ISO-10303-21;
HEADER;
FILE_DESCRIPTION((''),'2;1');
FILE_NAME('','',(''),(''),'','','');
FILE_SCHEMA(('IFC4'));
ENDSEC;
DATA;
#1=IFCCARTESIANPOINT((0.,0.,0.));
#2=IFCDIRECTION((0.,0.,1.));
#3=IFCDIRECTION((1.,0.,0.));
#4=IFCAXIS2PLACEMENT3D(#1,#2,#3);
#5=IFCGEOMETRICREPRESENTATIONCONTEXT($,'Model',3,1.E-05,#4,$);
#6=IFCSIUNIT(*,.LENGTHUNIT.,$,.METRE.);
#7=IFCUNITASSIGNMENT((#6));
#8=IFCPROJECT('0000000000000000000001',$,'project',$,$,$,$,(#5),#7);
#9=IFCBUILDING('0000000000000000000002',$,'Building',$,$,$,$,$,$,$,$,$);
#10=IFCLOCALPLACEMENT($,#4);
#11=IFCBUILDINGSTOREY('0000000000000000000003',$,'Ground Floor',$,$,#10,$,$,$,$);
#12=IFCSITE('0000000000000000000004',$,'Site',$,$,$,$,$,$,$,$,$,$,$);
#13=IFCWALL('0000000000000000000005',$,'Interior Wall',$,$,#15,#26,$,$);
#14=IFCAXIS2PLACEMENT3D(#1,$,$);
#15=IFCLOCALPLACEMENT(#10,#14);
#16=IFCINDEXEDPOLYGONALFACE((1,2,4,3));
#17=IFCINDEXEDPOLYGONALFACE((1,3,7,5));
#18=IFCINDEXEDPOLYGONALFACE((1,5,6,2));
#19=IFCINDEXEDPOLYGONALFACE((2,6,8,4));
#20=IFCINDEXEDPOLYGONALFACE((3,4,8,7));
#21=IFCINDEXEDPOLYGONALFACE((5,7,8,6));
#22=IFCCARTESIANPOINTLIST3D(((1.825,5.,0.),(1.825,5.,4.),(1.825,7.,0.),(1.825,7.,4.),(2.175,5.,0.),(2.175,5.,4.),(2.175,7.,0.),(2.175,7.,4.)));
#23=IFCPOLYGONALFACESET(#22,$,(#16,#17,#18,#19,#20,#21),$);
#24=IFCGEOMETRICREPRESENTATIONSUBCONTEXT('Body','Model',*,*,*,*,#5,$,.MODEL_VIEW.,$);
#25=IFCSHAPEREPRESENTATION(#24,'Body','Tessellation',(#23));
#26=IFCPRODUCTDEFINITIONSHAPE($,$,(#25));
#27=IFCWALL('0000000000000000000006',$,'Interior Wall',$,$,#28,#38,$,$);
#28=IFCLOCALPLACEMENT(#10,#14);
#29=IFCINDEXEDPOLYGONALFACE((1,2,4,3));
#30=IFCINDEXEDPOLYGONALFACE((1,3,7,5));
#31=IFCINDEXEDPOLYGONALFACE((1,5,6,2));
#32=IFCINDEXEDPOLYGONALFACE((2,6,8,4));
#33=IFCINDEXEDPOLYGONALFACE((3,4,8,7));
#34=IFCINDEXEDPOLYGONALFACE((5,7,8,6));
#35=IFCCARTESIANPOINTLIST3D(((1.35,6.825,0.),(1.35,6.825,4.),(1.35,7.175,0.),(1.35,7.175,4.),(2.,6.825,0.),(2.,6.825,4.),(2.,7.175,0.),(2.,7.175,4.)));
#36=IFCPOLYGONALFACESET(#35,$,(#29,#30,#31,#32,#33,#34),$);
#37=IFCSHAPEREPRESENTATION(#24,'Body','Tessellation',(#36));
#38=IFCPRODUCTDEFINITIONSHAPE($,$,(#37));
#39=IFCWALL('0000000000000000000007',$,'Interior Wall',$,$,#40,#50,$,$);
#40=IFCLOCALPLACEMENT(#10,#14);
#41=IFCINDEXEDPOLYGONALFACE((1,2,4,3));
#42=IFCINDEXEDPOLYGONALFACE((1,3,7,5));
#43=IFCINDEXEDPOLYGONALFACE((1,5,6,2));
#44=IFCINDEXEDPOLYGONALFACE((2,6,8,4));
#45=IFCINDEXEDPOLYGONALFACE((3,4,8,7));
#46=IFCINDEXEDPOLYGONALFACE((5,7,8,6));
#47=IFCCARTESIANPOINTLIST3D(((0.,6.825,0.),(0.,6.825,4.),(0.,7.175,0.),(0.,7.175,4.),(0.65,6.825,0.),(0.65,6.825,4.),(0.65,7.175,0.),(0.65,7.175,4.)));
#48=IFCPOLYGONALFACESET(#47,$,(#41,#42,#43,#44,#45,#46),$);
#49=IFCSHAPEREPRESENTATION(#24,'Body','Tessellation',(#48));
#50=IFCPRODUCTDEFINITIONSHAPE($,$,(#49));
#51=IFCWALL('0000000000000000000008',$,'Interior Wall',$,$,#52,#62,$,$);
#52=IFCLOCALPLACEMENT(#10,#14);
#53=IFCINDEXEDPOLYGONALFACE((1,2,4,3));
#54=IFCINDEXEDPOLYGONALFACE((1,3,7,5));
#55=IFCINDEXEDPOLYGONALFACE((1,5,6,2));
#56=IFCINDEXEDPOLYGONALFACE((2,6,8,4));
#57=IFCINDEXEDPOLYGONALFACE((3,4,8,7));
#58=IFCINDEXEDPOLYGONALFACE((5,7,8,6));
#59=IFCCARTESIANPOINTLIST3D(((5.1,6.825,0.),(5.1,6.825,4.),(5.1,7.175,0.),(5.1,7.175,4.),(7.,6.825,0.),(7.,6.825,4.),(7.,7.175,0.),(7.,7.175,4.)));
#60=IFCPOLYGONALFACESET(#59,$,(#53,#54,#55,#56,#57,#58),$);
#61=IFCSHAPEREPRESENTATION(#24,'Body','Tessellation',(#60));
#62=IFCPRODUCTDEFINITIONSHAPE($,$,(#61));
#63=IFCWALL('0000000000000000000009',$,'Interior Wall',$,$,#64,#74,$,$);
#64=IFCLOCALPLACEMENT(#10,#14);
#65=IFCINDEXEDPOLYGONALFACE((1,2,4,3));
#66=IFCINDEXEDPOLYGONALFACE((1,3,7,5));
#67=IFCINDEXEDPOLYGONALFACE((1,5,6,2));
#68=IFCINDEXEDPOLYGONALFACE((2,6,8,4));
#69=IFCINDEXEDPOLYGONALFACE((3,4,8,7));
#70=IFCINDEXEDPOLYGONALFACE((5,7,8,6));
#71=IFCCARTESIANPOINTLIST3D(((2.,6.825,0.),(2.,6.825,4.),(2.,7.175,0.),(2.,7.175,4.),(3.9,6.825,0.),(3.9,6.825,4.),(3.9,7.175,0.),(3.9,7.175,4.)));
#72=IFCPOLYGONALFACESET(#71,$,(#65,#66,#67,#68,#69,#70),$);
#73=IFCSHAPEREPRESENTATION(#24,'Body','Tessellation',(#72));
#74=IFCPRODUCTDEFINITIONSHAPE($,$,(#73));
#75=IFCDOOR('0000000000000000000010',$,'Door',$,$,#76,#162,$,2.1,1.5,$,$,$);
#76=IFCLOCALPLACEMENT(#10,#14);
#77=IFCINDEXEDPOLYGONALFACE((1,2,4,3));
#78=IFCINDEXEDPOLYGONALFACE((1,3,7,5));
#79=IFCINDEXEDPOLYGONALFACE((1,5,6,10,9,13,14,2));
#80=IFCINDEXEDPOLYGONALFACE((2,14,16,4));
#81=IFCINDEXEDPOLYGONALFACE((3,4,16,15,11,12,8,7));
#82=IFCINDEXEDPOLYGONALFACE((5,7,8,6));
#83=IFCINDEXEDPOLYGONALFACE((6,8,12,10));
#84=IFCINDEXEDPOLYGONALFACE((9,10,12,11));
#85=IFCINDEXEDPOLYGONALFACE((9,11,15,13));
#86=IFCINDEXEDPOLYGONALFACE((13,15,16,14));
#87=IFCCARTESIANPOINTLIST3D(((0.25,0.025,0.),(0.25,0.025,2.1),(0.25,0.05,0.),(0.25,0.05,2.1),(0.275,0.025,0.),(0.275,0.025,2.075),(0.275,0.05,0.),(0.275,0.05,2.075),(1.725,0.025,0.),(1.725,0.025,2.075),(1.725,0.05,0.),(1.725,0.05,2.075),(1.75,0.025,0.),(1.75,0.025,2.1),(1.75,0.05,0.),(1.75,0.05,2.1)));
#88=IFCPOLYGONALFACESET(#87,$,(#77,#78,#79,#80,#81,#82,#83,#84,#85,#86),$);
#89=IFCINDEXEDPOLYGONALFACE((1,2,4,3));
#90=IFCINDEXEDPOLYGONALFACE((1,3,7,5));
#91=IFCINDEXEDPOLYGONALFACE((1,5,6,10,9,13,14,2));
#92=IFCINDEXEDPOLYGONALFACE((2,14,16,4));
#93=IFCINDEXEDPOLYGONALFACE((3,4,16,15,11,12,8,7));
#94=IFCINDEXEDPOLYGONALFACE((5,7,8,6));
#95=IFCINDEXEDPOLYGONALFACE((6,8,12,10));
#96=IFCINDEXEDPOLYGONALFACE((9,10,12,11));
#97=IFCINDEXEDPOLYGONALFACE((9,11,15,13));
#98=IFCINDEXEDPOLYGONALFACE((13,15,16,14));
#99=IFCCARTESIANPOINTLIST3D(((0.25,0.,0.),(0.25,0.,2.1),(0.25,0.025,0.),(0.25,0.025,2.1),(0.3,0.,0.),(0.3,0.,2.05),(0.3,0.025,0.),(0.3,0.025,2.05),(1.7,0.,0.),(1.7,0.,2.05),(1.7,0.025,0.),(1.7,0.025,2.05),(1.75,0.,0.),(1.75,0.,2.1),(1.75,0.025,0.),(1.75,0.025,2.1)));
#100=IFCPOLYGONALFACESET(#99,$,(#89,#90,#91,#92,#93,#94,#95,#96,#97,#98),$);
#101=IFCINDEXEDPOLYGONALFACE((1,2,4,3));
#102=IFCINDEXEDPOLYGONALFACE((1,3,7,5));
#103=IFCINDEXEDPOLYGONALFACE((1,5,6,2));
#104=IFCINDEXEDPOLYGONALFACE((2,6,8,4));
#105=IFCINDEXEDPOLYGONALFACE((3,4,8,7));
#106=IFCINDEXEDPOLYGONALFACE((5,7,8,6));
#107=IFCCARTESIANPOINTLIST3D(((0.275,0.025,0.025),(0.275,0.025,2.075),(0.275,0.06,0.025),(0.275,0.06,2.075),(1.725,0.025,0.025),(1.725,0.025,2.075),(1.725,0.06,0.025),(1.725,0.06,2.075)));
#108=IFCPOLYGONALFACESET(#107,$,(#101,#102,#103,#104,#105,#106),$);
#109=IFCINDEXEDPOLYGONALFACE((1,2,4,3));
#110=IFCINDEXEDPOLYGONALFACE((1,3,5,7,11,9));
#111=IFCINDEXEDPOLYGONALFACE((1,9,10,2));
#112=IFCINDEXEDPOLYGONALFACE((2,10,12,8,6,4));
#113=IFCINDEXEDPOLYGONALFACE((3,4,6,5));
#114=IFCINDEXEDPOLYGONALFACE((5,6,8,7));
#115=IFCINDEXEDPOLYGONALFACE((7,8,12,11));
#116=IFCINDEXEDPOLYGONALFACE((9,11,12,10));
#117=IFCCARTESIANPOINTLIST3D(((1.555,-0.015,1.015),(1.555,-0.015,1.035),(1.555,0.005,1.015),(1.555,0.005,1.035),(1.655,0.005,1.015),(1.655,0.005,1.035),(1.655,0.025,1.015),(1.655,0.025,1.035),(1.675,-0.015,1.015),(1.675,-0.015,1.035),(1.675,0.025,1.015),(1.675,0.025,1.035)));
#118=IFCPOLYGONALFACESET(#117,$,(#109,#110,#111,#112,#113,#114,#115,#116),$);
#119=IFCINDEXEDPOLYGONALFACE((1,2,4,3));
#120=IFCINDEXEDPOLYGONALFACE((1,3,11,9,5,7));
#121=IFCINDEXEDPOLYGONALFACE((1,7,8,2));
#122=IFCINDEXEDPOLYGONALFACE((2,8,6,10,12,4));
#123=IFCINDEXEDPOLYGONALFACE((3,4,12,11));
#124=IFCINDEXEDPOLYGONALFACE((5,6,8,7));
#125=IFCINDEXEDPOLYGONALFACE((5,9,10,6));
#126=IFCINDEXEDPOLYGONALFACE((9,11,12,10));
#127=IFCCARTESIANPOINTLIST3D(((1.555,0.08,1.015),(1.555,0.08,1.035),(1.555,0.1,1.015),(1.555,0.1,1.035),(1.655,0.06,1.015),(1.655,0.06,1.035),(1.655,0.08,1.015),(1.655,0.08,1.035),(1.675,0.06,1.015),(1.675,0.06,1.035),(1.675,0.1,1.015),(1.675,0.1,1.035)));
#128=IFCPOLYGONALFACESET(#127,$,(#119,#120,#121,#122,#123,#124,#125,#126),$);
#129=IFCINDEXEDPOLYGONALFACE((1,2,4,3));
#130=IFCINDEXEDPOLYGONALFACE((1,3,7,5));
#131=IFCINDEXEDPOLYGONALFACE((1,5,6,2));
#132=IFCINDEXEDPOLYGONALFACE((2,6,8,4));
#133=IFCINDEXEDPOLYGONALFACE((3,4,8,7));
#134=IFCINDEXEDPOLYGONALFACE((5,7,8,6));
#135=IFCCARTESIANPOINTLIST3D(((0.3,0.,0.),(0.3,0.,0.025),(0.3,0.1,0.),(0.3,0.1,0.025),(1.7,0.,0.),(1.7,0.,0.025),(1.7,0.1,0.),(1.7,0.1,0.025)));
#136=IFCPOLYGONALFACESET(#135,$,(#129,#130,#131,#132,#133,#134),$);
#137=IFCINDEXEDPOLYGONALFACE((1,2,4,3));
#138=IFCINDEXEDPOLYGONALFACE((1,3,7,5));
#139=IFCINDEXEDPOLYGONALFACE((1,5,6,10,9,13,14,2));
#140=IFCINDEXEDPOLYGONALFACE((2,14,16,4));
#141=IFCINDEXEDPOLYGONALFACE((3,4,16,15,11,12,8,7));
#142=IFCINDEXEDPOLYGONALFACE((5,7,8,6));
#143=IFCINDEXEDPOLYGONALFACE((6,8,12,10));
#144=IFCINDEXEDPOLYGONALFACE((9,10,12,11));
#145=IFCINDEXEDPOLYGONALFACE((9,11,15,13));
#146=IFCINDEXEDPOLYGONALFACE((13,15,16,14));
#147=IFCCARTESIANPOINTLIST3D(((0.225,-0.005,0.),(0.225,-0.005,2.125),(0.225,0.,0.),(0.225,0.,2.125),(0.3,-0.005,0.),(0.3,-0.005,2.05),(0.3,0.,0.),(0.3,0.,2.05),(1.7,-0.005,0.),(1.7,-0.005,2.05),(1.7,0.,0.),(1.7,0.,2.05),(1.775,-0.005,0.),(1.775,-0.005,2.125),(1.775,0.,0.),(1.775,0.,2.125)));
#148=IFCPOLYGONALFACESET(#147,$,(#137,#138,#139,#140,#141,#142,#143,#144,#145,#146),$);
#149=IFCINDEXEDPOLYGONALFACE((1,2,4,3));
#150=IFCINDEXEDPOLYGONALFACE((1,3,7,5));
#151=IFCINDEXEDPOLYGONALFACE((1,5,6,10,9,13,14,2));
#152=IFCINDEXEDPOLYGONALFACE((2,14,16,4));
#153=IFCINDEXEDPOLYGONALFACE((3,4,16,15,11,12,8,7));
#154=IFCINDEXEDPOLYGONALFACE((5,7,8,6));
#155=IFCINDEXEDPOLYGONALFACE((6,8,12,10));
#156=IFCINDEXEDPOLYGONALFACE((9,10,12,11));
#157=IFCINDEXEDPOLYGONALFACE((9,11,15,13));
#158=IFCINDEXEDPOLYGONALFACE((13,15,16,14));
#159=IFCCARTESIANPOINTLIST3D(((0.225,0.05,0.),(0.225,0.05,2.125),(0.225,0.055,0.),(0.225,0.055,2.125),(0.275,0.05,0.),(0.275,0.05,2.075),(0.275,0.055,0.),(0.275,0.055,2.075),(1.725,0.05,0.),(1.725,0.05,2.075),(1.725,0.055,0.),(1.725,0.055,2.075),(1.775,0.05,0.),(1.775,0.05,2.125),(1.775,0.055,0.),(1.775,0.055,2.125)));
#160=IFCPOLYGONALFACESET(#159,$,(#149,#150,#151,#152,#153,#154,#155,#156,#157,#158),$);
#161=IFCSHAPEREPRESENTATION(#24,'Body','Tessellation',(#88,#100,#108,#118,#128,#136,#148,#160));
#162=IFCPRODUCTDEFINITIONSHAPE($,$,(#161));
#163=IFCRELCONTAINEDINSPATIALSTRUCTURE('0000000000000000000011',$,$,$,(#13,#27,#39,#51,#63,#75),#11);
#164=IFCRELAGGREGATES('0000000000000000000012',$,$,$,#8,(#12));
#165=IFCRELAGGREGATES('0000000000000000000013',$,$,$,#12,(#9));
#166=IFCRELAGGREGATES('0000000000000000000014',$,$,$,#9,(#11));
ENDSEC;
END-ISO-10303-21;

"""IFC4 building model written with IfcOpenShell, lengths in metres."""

from ifc_helpers import new_model, si_unit, frame, origin_with_axes, place, context, subcontext, project, spatial, line, indexed_curve, outline, extrude, element, save


model = new_model("IFC4")

# Units and contexts
model_context = context("Model", 3, precision=1e-05, world=origin_with_axes())
body_context = subcontext(model_context, "Body", "Model", "MODEL_VIEW")
ifc_project = project(units=[si_unit("LENGTHUNIT", "METRE")], contexts=[model_context])

# Site, building, storey
site = spatial("IfcSite", under=ifc_project, Name="Site")
building = spatial("IfcBuilding", under=site, Name="Building")
storey_placement = place(None, origin_with_axes())
storey = spatial("IfcBuildingStorey", under=building, at=storey_placement, Name="Ground Floor")

# Walls
wall_1_placement = place(storey_placement, frame((2.0, 5.0, 0.0), z_axis=(0.0, 0.0, 1.0), x_axis=(0.0, 1.0, 0.0)))
element("IfcWall", 1, at=wall_1_placement, inside=storey, Name="Interior Wall", context=body_context, shape_type="SweptSolid", body=[
    extrude(outline(indexed_curve([(0.0, 0.0), (0.0, 0.35), (2.0, 0.35), (2.0, 0.0), (0.0, 0.0)], self_intersect=False)), frame((0.0, -0.175, 0.0), z_axis=(0.0, 0.0, 1.0), x_axis=(1.0, 0.0, 0.0)), (0.0, 0.0, 1.0), 4.0),
])
for number, where, z_axis, x_axis, name in (
    (2, (2.0, 7.0, 0.0), (0.0, 0.0, 1.0), (-1.0, 0.0, 0.0), "Interior Wall"),
    (3, (0.65, 7.0, 0.0), (0.0, 0.0, 1.0), (-1.0, 0.0, 0.0), "Interior Wall"),
):
    element("IfcWall", number, at=place(storey_placement, frame(where, z_axis=z_axis, x_axis=x_axis)), inside=storey, Name=name, context=body_context, shape_type="SweptSolid", body=[
        extrude(outline(indexed_curve([(0.0, 0.0), (0.0, 0.35), (0.65, 0.35), (0.65, 0.0), (0.0, 0.0)], self_intersect=False)), frame((0.0, -0.175, 0.0), z_axis=(0.0, 0.0, 1.0), x_axis=(1.0, 0.0, 0.0)), (0.0, 0.0, 1.0), 4.0),
    ])
wall_2_placement = place(storey_placement, frame((7.0, 7.0, 0.0), z_axis=(0.0, 0.0, 1.0), x_axis=(-1.0, 0.0, 0.0)))
element("IfcWall", 4, at=wall_2_placement, inside=storey, Name="Interior Wall", context=body_context, shape_type="SweptSolid", body=[
    extrude(outline(indexed_curve([(0.0, 0.0), (0.0, 0.35), (1.9, 0.35), (1.9, 0.0), (0.0, 0.0)], self_intersect=False)), frame((0.0, -0.175, 0.0), z_axis=(0.0, 0.0, 1.0), x_axis=(1.0, 0.0, 0.0)), (0.0, 0.0, 1.0), 4.0),
])
wall_3_placement = place(storey_placement, frame((3.9, 7.0, 0.0), z_axis=(0.0, 0.0, 1.0), x_axis=(-1.0, 0.0, 0.0)))
element("IfcWall", 5, at=wall_3_placement, inside=storey, Name="Interior Wall", context=body_context, shape_type="SweptSolid", body=[
    extrude(outline(indexed_curve([(0.0, 0.0), (0.0, 0.35), (1.9, 0.35), (1.9, 0.0), (0.0, 0.0)], self_intersect=False)), frame((0.0, -0.175, 0.0), z_axis=(0.0, 0.0, 1.0), x_axis=(1.0, 0.0, 0.0)), (0.0, 0.0, 1.0), 4.0),
])

# Door
door_1_placement = place(storey_placement, frame((0.25, 0.0, 0.0), z_axis=(0.0, 0.0, 1.0), x_axis=(1.0, 0.0, 0.0)))
element("IfcDoor", 6, at=door_1_placement, inside=storey, Name="Door", OverallHeight=2.1, OverallWidth=1.5, context=body_context, shape_type="SweptSolid", body=[
    extrude(outline(indexed_curve([(0.0, 0.0), (0.0, 2.1), (1.5, 2.1), (1.5, 0.0), (1.475, 0.0), (1.475, 2.075), (0.025, 2.075), (0.025, 0.0)], segments=[line(1, 2, 3, 4, 5, 6, 7, 8, 1)])), frame((0.0, 0.025, 0.0), z_axis=(0.0, -1.0, 0.0), x_axis=(1.0, 0.0, 0.0)), (0.0, 0.0, -1.0), 0.025),
    extrude(outline(indexed_curve([(0.0, 0.0), (0.0, 2.1), (1.5, 2.1), (1.5, 0.0), (1.45, 0.0), (1.45, 2.05), (0.05, 2.05), (0.05, 0.0)], segments=[line(1, 2, 3, 4, 5, 6, 7, 8, 1)])), frame((0.0, 0.0, 0.0), z_axis=(0.0, -1.0, 0.0), x_axis=(1.0, 0.0, 0.0)), (0.0, 0.0, -1.0), 0.025),
    extrude(outline(indexed_curve([(0.0, 0.0), (1.45, 0.0), (1.45, 0.035), (0.0, 0.035)], segments=[line(1, 2, 3, 4, 1)])), frame((0.025, 0.025, 0.025), z_axis=(0.0, 0.0, 1.0), x_axis=(1.0, 0.0, 0.0)), (0.0, 0.0, 1.0), 2.05),
    extrude(outline(indexed_curve([(0.0, 0.0), (0.0, -0.04), (-0.12, -0.04), (-0.12, -0.02), (-0.02, -0.02), (-0.02, 0.0)], segments=[line(1, 2, 3, 4, 5, 6, 1)])), frame((1.425, 0.025, 1.015), z_axis=(0.0, 0.0, 1.0), x_axis=(1.0, 0.0, 0.0)), (0.0, 0.0, 1.0), 0.02),
    extrude(outline(indexed_curve([(0.0, 0.0), (0.0, 0.04), (-0.12, 0.04), (-0.12, 0.02), (-0.02, 0.02), (-0.02, 0.0)], segments=[line(1, 2, 3, 4, 5, 6, 1)])), frame((1.425, 0.06, 1.015), z_axis=(0.0, 0.0, 1.0), x_axis=(1.0, 0.0, 0.0)), (0.0, 0.0, 1.0), 0.02),
    extrude(outline(indexed_curve([(0.0, 0.0), (1.4, 0.0), (1.4, 0.1), (0.0, 0.1)], segments=[line(1, 2, 3, 4, 1)])), frame((0.05, 0.0, 0.0), z_axis=(0.0, 0.0, 1.0), x_axis=(1.0, 0.0, 0.0)), (0.0, 0.0, 1.0), 0.025),
    extrude(outline(indexed_curve([(0.0, 0.0), (0.0, 2.125), (1.55, 2.125), (1.55, 0.0), (1.475, 0.0), (1.475, 2.05), (0.075, 2.05), (0.075, 0.0)], segments=[line(1, 2, 3, 4, 5, 6, 7, 8, 1)])), frame((-0.025, -0.005, 0.0), z_axis=(0.0, -1.0, 0.0), x_axis=(1.0, 0.0, 0.0)), (0.0, 0.0, -1.0), 0.005),
    extrude(outline(indexed_curve([(0.0, 0.0), (0.0, 2.125), (1.55, 2.125), (1.55, 0.0), (1.5, 0.0), (1.5, 2.075), (0.05, 2.075), (0.05, 0.0)], segments=[line(1, 2, 3, 4, 5, 6, 7, 8, 1)])), frame((-0.025, 0.05, 0.0), z_axis=(0.0, -1.0, 0.0), x_axis=(1.0, 0.0, 0.0)), (0.0, 0.0, -1.0), 0.005),
])

save(model, "model.ifc")
